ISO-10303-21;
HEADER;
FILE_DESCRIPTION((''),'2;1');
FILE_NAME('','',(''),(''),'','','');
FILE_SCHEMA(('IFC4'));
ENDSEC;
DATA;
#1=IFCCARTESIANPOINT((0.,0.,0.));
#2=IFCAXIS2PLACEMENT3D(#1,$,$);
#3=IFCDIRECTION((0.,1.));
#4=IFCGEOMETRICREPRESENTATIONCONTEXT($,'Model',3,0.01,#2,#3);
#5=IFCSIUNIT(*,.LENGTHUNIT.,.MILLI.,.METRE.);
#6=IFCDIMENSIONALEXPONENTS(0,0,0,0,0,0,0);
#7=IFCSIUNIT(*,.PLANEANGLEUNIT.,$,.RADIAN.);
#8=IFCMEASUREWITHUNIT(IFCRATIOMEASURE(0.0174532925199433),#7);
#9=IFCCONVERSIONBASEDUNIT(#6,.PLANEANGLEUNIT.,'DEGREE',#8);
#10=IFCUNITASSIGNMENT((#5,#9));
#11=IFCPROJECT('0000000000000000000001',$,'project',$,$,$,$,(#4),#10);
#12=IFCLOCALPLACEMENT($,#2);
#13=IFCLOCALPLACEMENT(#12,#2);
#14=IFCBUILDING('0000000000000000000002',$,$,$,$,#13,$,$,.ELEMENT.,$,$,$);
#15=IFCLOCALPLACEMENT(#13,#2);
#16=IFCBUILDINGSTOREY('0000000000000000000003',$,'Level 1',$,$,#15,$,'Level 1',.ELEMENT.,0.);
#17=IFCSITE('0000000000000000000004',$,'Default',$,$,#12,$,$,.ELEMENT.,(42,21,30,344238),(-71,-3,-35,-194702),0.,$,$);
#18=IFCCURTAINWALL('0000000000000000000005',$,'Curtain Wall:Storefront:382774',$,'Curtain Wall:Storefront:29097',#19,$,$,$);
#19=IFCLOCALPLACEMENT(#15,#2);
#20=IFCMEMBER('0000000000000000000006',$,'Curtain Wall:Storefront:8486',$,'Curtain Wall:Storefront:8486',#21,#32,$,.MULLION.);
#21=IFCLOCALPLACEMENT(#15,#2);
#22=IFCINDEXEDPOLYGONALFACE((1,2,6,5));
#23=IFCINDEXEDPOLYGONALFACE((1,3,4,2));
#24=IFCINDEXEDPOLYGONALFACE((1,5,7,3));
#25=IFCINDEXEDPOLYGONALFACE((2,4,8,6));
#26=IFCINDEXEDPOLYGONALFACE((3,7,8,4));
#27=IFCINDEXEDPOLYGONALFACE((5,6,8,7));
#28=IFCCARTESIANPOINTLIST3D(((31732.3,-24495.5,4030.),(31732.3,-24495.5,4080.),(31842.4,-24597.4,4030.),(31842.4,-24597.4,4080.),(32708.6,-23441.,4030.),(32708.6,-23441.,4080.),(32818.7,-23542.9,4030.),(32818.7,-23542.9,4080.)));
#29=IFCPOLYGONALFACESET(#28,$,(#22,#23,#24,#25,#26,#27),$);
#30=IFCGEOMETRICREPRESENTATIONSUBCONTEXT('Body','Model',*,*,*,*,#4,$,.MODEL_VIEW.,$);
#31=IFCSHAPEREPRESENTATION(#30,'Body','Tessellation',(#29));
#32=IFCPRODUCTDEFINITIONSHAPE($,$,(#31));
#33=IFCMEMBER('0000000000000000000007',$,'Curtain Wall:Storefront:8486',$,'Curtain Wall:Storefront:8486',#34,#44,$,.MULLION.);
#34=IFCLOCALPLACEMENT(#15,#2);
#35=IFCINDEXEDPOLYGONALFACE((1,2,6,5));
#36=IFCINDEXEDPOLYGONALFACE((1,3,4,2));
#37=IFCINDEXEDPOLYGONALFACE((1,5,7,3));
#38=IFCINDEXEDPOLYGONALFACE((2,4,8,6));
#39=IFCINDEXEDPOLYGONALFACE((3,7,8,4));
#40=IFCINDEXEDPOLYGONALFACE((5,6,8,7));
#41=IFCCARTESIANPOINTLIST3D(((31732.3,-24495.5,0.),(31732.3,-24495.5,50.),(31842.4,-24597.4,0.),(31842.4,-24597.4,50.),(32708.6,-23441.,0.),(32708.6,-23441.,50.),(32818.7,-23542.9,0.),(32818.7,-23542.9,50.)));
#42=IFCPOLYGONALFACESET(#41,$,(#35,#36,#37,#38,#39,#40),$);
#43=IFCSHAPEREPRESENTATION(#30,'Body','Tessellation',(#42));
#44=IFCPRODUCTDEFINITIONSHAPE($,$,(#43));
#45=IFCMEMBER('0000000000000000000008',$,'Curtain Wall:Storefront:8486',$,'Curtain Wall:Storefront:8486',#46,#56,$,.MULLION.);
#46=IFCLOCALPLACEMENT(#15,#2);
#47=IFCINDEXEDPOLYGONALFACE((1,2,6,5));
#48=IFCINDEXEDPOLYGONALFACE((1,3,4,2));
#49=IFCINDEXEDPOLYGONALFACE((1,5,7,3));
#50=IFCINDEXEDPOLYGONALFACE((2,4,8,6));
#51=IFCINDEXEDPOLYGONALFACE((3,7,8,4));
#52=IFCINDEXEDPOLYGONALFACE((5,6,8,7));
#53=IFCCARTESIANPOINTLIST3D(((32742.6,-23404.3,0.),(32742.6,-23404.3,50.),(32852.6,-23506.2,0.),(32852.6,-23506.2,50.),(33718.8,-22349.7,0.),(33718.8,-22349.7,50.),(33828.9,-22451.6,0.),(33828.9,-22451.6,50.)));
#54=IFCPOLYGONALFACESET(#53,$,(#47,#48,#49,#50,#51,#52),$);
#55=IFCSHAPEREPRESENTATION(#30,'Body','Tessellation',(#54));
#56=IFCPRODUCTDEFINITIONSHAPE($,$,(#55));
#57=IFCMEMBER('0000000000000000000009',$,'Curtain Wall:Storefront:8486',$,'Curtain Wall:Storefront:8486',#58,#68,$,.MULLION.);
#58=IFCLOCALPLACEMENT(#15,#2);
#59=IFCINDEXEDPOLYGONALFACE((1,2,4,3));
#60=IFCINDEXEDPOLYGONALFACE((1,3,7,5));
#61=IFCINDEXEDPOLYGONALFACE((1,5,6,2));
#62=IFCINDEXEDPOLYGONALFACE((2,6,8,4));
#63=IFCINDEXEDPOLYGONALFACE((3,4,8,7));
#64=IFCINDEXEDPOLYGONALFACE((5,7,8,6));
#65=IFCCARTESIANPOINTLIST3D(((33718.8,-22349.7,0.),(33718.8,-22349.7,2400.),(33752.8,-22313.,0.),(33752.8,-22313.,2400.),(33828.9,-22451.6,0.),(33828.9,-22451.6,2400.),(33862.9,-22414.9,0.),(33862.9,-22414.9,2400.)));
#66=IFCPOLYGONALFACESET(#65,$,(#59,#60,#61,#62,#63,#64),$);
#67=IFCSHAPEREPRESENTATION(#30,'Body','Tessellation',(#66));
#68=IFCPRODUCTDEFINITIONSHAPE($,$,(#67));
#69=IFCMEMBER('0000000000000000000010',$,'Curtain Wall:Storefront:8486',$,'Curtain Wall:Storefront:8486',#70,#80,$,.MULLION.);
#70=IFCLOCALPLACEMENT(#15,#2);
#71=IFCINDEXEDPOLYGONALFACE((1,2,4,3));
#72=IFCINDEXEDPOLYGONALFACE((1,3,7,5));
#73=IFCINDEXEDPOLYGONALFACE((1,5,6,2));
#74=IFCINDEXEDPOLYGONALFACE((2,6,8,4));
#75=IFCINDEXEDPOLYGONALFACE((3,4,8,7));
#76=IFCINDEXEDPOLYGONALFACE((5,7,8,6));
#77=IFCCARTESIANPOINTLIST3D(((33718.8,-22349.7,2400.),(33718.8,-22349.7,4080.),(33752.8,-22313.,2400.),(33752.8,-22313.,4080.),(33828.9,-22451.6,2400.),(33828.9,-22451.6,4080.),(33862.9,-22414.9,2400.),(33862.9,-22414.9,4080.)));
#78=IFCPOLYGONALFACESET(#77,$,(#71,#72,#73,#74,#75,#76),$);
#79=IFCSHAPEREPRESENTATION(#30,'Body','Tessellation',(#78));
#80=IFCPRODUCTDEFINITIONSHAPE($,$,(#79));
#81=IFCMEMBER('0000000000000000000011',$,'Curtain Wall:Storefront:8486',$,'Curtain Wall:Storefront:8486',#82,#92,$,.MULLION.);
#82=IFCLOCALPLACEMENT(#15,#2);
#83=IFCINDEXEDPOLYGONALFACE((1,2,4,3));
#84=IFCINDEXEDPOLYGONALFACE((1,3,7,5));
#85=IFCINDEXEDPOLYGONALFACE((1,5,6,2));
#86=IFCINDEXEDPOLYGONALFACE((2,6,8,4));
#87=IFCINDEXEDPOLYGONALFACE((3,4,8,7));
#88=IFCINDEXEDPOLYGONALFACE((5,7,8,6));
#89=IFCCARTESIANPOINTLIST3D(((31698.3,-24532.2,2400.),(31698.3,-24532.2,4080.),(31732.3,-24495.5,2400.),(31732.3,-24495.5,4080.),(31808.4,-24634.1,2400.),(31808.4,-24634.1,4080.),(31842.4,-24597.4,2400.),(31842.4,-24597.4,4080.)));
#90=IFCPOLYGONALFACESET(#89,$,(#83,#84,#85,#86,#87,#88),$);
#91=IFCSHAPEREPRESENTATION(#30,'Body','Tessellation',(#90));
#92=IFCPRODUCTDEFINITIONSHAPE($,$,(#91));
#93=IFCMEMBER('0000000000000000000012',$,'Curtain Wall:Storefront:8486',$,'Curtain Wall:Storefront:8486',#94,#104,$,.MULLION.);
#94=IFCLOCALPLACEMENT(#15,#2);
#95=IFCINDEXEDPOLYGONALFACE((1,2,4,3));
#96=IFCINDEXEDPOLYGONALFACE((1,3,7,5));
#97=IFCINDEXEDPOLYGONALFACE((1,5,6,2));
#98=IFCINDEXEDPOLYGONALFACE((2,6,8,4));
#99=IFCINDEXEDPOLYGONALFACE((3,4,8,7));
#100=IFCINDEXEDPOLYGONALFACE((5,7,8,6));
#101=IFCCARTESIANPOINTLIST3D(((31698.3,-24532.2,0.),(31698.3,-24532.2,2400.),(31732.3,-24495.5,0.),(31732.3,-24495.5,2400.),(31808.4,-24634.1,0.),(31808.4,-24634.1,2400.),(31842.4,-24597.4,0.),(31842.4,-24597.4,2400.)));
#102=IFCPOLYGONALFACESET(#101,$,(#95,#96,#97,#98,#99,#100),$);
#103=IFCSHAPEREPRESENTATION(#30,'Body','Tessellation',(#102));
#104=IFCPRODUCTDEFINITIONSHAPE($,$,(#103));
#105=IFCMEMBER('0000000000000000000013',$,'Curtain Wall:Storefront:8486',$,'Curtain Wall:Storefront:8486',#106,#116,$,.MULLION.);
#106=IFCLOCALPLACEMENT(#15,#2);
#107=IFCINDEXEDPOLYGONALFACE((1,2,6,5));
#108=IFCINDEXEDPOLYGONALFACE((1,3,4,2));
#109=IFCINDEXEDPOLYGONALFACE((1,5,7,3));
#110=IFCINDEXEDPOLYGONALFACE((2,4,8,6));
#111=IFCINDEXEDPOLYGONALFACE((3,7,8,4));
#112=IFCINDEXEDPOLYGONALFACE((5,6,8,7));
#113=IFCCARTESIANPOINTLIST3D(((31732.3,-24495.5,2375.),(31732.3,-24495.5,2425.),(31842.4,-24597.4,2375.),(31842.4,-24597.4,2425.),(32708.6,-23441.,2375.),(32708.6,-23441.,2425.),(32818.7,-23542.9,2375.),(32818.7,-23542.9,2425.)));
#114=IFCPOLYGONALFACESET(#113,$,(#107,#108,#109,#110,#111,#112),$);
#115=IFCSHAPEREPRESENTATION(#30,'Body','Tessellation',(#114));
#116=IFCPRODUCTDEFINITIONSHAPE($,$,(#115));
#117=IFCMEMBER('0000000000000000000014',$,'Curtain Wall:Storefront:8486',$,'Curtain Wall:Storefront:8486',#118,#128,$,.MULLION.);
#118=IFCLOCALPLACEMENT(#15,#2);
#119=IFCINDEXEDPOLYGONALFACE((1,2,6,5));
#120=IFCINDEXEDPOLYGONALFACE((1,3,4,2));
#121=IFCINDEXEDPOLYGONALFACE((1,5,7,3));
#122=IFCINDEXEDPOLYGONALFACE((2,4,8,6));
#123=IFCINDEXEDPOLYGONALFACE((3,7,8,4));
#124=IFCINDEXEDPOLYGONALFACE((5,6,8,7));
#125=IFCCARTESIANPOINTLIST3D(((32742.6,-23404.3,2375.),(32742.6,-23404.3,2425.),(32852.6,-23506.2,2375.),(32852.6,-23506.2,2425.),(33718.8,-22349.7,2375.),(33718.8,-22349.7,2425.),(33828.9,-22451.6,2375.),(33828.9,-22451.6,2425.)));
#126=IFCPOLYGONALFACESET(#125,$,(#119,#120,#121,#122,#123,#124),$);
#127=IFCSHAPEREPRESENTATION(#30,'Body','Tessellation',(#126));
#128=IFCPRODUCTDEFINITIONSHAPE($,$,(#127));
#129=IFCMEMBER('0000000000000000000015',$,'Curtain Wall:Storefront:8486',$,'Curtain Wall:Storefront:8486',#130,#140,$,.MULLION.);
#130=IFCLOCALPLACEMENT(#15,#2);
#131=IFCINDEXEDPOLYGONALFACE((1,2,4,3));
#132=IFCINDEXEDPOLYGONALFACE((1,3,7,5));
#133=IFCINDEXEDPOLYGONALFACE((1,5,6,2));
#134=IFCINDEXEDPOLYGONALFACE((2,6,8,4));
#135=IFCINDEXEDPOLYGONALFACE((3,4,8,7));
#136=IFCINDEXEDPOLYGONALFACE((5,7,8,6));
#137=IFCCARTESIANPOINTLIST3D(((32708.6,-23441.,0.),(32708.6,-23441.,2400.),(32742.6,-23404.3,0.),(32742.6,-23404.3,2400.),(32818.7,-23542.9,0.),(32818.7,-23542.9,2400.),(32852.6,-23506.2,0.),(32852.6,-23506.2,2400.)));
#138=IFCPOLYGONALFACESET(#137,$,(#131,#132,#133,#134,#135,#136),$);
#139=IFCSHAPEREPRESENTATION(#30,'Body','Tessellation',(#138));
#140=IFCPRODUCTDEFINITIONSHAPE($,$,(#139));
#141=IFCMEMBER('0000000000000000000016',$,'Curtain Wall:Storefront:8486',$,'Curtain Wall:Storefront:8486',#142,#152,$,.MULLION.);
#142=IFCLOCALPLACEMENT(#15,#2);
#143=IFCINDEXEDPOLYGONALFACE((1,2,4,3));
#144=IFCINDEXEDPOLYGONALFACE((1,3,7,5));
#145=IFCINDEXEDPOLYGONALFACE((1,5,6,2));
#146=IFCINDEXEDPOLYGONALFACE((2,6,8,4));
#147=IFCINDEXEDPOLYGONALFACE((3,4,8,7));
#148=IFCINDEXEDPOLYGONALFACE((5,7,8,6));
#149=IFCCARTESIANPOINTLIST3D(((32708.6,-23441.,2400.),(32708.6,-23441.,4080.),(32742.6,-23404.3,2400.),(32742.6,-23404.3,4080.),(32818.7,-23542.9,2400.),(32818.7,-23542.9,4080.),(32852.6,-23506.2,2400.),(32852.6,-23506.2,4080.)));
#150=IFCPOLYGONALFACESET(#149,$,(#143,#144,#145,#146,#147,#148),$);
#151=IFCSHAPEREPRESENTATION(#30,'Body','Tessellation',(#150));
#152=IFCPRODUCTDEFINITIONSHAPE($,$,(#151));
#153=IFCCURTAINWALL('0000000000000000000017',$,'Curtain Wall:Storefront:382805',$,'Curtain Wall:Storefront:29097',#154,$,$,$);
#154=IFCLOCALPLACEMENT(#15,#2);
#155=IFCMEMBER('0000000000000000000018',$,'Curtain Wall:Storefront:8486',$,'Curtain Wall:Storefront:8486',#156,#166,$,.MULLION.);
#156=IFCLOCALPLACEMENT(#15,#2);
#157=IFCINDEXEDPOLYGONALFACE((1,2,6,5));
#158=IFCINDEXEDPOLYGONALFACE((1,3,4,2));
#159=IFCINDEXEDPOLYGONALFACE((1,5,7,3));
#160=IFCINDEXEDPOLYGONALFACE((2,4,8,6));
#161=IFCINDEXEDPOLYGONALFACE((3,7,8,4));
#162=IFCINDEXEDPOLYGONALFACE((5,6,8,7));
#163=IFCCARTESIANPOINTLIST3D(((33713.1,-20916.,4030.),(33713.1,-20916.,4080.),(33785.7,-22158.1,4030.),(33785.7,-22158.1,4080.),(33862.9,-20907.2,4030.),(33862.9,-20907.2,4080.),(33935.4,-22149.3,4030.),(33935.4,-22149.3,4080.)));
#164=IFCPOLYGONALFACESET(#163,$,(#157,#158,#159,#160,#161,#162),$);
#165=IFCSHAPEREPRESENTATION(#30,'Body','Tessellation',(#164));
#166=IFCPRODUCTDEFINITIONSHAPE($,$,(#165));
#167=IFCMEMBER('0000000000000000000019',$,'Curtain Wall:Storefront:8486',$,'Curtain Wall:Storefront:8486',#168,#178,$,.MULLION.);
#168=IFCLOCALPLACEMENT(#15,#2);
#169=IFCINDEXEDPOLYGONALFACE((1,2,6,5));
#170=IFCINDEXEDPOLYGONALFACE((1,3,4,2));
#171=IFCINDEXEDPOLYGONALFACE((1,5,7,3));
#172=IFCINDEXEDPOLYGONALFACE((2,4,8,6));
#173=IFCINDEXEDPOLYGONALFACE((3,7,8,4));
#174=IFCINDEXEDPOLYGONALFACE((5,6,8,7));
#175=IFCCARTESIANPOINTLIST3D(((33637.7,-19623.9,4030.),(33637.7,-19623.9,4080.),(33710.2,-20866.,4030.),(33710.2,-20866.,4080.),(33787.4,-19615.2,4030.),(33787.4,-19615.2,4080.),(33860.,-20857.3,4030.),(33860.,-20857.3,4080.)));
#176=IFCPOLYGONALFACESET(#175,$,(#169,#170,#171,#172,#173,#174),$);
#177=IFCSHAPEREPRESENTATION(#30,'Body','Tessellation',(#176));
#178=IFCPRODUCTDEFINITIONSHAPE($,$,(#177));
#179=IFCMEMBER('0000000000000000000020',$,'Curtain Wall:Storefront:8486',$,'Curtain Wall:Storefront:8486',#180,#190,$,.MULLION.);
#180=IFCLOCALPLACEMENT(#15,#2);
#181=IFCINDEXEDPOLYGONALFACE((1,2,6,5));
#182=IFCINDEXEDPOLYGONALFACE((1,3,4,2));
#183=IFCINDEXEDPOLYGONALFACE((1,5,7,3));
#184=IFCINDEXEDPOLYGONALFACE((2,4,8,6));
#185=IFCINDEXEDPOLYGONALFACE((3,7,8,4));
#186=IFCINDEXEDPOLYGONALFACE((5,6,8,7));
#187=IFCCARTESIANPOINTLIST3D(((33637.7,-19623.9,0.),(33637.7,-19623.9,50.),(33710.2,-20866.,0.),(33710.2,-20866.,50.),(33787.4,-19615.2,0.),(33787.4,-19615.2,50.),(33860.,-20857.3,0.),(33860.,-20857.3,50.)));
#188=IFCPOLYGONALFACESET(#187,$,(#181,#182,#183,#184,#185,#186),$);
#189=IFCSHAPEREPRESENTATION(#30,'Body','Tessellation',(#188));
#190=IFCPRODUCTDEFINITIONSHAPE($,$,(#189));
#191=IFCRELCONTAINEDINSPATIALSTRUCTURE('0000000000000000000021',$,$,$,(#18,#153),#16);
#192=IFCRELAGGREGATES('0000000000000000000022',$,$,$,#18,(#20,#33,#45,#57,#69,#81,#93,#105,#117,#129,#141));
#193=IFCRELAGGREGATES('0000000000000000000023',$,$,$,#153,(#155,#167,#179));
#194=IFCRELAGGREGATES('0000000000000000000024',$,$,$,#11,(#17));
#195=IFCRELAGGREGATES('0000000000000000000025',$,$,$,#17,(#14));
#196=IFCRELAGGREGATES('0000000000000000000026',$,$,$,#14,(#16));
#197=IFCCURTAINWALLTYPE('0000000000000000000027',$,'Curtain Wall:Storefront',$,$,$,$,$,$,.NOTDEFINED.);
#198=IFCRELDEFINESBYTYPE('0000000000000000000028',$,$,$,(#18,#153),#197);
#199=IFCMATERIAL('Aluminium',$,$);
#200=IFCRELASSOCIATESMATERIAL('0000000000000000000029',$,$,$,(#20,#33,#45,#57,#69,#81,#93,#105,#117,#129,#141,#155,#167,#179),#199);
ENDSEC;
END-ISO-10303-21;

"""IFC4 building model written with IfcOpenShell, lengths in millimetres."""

from ifc_helpers import new_model, entity, si_unit, converted_unit, direction, frame, frame_2d, origin, origin_2d_with_axis, place, context, subcontext, project, spatial, rectangle, extrude, material, type_object, element, aggregate, save


model = new_model("IFC4")

# Units and contexts
model_context = context("Model", 3, precision=0.01, world=origin(), true_north=direction((0.0, 1.0)))
body_context = subcontext(model_context, "Body", "Model", "MODEL_VIEW")
ifc_project = project(units=[si_unit("LENGTHUNIT", "METRE", prefix="MILLI"), converted_unit("PLANEANGLEUNIT", "DEGREE", entity("IfcRatioMeasure", 0.0174532925199433), si_unit("PLANEANGLEUNIT", "RADIAN"), dimensions=[0, 0, 0, 0, 0, 0, 0])], contexts=[model_context])

# Site, building, storey
site_placement = place(None, origin())
site = spatial("IfcSite", under=ifc_project, at=site_placement, Name="Default", CompositionType="ELEMENT", RefLatitude=(42, 21, 30, 344238), RefLongitude=(-71, -3, -35, -194702), RefElevation=0.0)
building_placement = place(site_placement, origin())
building = spatial("IfcBuilding", under=site, at=building_placement, CompositionType="ELEMENT")
storey_placement = place(building_placement, origin())
storey = spatial("IfcBuildingStorey", under=building, at=storey_placement, Name="Level 1", LongName="Level 1", CompositionType="ELEMENT", Elevation=0.0)

# Curtain walls, members
curtain_wall_type = type_object("IfcCurtainWallType", Name="Curtain Wall:Storefront", PredefinedType="NOTDEFINED")
ifc_material = material(Name="Aluminium")
curtain_wall_1_placement = place(storey_placement, origin())
curtain_wall_1 = element("IfcCurtainWall", 1, at=curtain_wall_1_placement, inside=storey, type_object=curtain_wall_type, Name="Curtain Wall:Storefront:382774", ObjectType="Curtain Wall:Storefront:29097")
member_1_placement = place(curtain_wall_1_placement, origin())
member_1 = element("IfcMember", 2, at=member_1_placement, material=ifc_material, Name="Curtain Wall:Storefront:8486", ObjectType="Curtain Wall:Storefront:8486", PredefinedType="MULLION", context=body_context, shape_type="SweptSolid", body=[
    extrude(rectangle(XDim=50.0, YDim=150.0, at=frame_2d((0.0, 0.0), x_axis=(1.0, 0.0))), frame((32763.6, -23491.9, 4055.0), z_axis=(-0.679334, -0.733829, 0.0), x_axis=(0.0, 0.0, -1.0)), (0.0, 0.0, 1.0), 1437.1),
])
member_2_placement = place(curtain_wall_1_placement, origin())
member_2 = element("IfcMember", 3, at=member_2_placement, material=ifc_material, Name="Curtain Wall:Storefront:8486", ObjectType="Curtain Wall:Storefront:8486", PredefinedType="MULLION", context=body_context, shape_type="SweptSolid", body=[
    extrude(rectangle(XDim=50.0, YDim=150.0, at=frame_2d((0.0, 0.0), x_axis=(1.0, 0.0))), frame((31787.3, -24546.5, 25.0), z_axis=(0.679334, 0.733829, 0.0), x_axis=(0.0, 0.0, -1.0)), (0.0, 0.0, 1.0), 1437.1),
])
member_3_placement = place(curtain_wall_1_placement, origin())
member_3 = element("IfcMember", 4, at=member_3_placement, material=ifc_material, Name="Curtain Wall:Storefront:8486", ObjectType="Curtain Wall:Storefront:8486", PredefinedType="MULLION", context=body_context, shape_type="SweptSolid", body=[
    extrude(rectangle(XDim=50.0, YDim=150.0, at=frame_2d((0.0, 0.0), x_axis=(1.0, 0.0))), frame((32797.6, -23455.2, 25.0), z_axis=(0.679334, 0.733829, 0.0), x_axis=(0.0, 0.0, -1.0)), (0.0, 0.0, 1.0), 1437.1),
])
member_4_placement = place(curtain_wall_1_placement, origin())
member_4 = element("IfcMember", 5, at=member_4_placement, material=ifc_material, Name="Curtain Wall:Storefront:8486", ObjectType="Curtain Wall:Storefront:8486", PredefinedType="MULLION", context=body_context, shape_type="SweptSolid", body=[
    extrude(rectangle(XDim=50.0, YDim=150.0, at=frame_2d((0.0, 0.0), x_axis=(1.0, 0.0))), frame((33790.8, -22382.3, 0.0), z_axis=(0.0, 0.0, 1.0), x_axis=(0.679334, 0.733829, 0.0)), (0.0, 0.0, 1.0), 2400.0),
])
member_5_placement = place(curtain_wall_1_placement, origin())
member_5 = element("IfcMember", 6, at=member_5_placement, material=ifc_material, Name="Curtain Wall:Storefront:8486", ObjectType="Curtain Wall:Storefront:8486", PredefinedType="MULLION", context=body_context, shape_type="SweptSolid", body=[
    extrude(rectangle(XDim=50.0, YDim=150.0, at=frame_2d((0.0, 0.0), x_axis=(1.0, 0.0))), frame((33790.8, -22382.3, 2400.0), z_axis=(0.0, 0.0, 1.0), x_axis=(0.679334, 0.733829, 0.0)), (0.0, 0.0, 1.0), 1680.0),
])
member_6_placement = place(curtain_wall_1_placement, origin())
member_6 = element("IfcMember", 7, at=member_6_placement, material=ifc_material, Name="Curtain Wall:Storefront:8486", ObjectType="Curtain Wall:Storefront:8486", PredefinedType="MULLION", context=body_context, shape_type="SweptSolid", body=[
    extrude(rectangle(XDim=150.0, YDim=50.0, at=frame_2d((0.0, 0.0), x_axis=(1.0, 0.0))), frame((31770.4, -24564.8, 4080.0), z_axis=(0.0, 0.0, -1.0), x_axis=(0.733829, -0.679334, 0.0)), (0.0, 0.0, 1.0), 1680.0),
])
member_7_placement = place(curtain_wall_1_placement, origin())
member_7 = element("IfcMember", 8, at=member_7_placement, material=ifc_material, Name="Curtain Wall:Storefront:8486", ObjectType="Curtain Wall:Storefront:8486", PredefinedType="MULLION", context=body_context, shape_type="SweptSolid", body=[
    extrude(rectangle(XDim=150.0, YDim=50.0, at=frame_2d((0.0, 0.0), x_axis=(1.0, 0.0))), frame((31770.4, -24564.8, 2400.0), z_axis=(0.0, 0.0, -1.0), x_axis=(0.733829, -0.679334, 0.0)), (0.0, 0.0, 1.0), 2400.0),
])
member_8_placement = place(curtain_wall_1_placement, origin())
member_8 = element("IfcMember", 9, at=member_8_placement, material=ifc_material, Name="Curtain Wall:Storefront:8486", ObjectType="Curtain Wall:Storefront:8486", PredefinedType="MULLION", context=body_context, shape_type="SweptSolid", body=[
    extrude(rectangle(XDim=50.0, YDim=150.0, at=origin_2d_with_axis()), frame((32763.6, -23491.9, 2400.0), z_axis=(-0.679334, -0.733829, 0.0), x_axis=(0.0, 0.0, -1.0)), (0.0, 0.0, 1.0), 1437.1),
])
member_9_placement = place(curtain_wall_1_placement, origin())
member_9 = element("IfcMember", 10, at=member_9_placement, material=ifc_material, Name="Curtain Wall:Storefront:8486", ObjectType="Curtain Wall:Storefront:8486", PredefinedType="MULLION", context=body_context, shape_type="SweptSolid", body=[
    extrude(rectangle(XDim=50.0, YDim=150.0, at=origin_2d_with_axis()), frame((33773.9, -22400.6, 2400.0), z_axis=(-0.679334, -0.733829, 0.0), x_axis=(0.0, 0.0, -1.0)), (0.0, 0.0, 1.0), 1437.1),
])
member_10_placement = place(curtain_wall_1_placement, origin())
member_10 = element("IfcMember", 11, at=member_10_placement, material=ifc_material, Name="Curtain Wall:Storefront:8486", ObjectType="Curtain Wall:Storefront:8486", PredefinedType="MULLION", context=body_context, shape_type="SweptSolid", body=[
    extrude(rectangle(XDim=50.0, YDim=150.0, at=frame_2d((0.0, 0.0), x_axis=(1.0, 0.0))), frame((32780.6, -23473.6, 0.0), z_axis=(0.0, 0.0, 1.0), x_axis=(0.679334, 0.733829, 0.0)), (0.0, 0.0, 1.0), 2400.0),
])
member_11_placement = place(curtain_wall_1_placement, origin())
member_11 = element("IfcMember", 12, at=member_11_placement, material=ifc_material, Name="Curtain Wall:Storefront:8486", ObjectType="Curtain Wall:Storefront:8486", PredefinedType="MULLION", context=body_context, shape_type="SweptSolid", body=[
    extrude(rectangle(XDim=50.0, YDim=150.0, at=frame_2d((0.0, 0.0), x_axis=(1.0, 0.0))), frame((32780.6, -23473.6, 2400.0), z_axis=(0.0, 0.0, 1.0), x_axis=(0.679334, 0.733829, 0.0)), (0.0, 0.0, 1.0), 1680.0),
])
aggregate(curtain_wall_1, [member_1, member_2, member_3, member_4, member_5, member_6, member_7, member_8, member_9, member_10, member_11])
curtain_wall_2_placement = place(storey_placement, origin())
curtain_wall_2 = element("IfcCurtainWall", 13, at=curtain_wall_2_placement, inside=storey, type_object=curtain_wall_type, Name="Curtain Wall:Storefront:382805", ObjectType="Curtain Wall:Storefront:29097")
member_12_placement = place(curtain_wall_2_placement, origin())
member_12 = element("IfcMember", 14, at=member_12_placement, material=ifc_material, Name="Curtain Wall:Storefront:8486", ObjectType="Curtain Wall:Storefront:8486", PredefinedType="MULLION", context=body_context, shape_type="SweptSolid", body=[
    extrude(rectangle(XDim=50.0, YDim=150.0, at=frame_2d((0.0, 0.0), x_axis=(1.0, 0.0))), frame((33860.6, -22153.7, 4055.0), z_axis=(-0.058298, 0.998299, 0.0), x_axis=(0.0, 0.0, -1.0)), (0.0, 0.0, 1.0), 1244.2),
])
member_13_placement = place(curtain_wall_2_placement, origin())
member_13 = element("IfcMember", 15, at=member_13_placement, material=ifc_material, Name="Curtain Wall:Storefront:8486", ObjectType="Curtain Wall:Storefront:8486", PredefinedType="MULLION", context=body_context, shape_type="SweptSolid", body=[
    extrude(rectangle(XDim=50.0, YDim=150.0, at=frame_2d((0.0, 0.0), x_axis=(1.0, 0.0))), frame((33785.1, -20861.7, 4055.0), z_axis=(-0.058298, 0.998299, 0.0), x_axis=(0.0, 0.0, -1.0)), (0.0, 0.0, 1.0), 1244.2),
])
member_14_placement = place(curtain_wall_2_placement, origin())
member_14 = element("IfcMember", 16, at=member_14_placement, material=ifc_material, Name="Curtain Wall:Storefront:8486", ObjectType="Curtain Wall:Storefront:8486", PredefinedType="MULLION", context=body_context, shape_type="SweptSolid", body=[
    extrude(rectangle(XDim=50.0, YDim=150.0, at=origin_2d_with_axis()), frame((33712.6, -19619.5, 25.0), z_axis=(0.058298, -0.998299, 0.0), x_axis=(0.0, 0.0, -1.0)), (0.0, 0.0, 1.0), 1244.2),
])
aggregate(curtain_wall_2, [member_12, member_13, member_14])

save(model, "model.ifc")
